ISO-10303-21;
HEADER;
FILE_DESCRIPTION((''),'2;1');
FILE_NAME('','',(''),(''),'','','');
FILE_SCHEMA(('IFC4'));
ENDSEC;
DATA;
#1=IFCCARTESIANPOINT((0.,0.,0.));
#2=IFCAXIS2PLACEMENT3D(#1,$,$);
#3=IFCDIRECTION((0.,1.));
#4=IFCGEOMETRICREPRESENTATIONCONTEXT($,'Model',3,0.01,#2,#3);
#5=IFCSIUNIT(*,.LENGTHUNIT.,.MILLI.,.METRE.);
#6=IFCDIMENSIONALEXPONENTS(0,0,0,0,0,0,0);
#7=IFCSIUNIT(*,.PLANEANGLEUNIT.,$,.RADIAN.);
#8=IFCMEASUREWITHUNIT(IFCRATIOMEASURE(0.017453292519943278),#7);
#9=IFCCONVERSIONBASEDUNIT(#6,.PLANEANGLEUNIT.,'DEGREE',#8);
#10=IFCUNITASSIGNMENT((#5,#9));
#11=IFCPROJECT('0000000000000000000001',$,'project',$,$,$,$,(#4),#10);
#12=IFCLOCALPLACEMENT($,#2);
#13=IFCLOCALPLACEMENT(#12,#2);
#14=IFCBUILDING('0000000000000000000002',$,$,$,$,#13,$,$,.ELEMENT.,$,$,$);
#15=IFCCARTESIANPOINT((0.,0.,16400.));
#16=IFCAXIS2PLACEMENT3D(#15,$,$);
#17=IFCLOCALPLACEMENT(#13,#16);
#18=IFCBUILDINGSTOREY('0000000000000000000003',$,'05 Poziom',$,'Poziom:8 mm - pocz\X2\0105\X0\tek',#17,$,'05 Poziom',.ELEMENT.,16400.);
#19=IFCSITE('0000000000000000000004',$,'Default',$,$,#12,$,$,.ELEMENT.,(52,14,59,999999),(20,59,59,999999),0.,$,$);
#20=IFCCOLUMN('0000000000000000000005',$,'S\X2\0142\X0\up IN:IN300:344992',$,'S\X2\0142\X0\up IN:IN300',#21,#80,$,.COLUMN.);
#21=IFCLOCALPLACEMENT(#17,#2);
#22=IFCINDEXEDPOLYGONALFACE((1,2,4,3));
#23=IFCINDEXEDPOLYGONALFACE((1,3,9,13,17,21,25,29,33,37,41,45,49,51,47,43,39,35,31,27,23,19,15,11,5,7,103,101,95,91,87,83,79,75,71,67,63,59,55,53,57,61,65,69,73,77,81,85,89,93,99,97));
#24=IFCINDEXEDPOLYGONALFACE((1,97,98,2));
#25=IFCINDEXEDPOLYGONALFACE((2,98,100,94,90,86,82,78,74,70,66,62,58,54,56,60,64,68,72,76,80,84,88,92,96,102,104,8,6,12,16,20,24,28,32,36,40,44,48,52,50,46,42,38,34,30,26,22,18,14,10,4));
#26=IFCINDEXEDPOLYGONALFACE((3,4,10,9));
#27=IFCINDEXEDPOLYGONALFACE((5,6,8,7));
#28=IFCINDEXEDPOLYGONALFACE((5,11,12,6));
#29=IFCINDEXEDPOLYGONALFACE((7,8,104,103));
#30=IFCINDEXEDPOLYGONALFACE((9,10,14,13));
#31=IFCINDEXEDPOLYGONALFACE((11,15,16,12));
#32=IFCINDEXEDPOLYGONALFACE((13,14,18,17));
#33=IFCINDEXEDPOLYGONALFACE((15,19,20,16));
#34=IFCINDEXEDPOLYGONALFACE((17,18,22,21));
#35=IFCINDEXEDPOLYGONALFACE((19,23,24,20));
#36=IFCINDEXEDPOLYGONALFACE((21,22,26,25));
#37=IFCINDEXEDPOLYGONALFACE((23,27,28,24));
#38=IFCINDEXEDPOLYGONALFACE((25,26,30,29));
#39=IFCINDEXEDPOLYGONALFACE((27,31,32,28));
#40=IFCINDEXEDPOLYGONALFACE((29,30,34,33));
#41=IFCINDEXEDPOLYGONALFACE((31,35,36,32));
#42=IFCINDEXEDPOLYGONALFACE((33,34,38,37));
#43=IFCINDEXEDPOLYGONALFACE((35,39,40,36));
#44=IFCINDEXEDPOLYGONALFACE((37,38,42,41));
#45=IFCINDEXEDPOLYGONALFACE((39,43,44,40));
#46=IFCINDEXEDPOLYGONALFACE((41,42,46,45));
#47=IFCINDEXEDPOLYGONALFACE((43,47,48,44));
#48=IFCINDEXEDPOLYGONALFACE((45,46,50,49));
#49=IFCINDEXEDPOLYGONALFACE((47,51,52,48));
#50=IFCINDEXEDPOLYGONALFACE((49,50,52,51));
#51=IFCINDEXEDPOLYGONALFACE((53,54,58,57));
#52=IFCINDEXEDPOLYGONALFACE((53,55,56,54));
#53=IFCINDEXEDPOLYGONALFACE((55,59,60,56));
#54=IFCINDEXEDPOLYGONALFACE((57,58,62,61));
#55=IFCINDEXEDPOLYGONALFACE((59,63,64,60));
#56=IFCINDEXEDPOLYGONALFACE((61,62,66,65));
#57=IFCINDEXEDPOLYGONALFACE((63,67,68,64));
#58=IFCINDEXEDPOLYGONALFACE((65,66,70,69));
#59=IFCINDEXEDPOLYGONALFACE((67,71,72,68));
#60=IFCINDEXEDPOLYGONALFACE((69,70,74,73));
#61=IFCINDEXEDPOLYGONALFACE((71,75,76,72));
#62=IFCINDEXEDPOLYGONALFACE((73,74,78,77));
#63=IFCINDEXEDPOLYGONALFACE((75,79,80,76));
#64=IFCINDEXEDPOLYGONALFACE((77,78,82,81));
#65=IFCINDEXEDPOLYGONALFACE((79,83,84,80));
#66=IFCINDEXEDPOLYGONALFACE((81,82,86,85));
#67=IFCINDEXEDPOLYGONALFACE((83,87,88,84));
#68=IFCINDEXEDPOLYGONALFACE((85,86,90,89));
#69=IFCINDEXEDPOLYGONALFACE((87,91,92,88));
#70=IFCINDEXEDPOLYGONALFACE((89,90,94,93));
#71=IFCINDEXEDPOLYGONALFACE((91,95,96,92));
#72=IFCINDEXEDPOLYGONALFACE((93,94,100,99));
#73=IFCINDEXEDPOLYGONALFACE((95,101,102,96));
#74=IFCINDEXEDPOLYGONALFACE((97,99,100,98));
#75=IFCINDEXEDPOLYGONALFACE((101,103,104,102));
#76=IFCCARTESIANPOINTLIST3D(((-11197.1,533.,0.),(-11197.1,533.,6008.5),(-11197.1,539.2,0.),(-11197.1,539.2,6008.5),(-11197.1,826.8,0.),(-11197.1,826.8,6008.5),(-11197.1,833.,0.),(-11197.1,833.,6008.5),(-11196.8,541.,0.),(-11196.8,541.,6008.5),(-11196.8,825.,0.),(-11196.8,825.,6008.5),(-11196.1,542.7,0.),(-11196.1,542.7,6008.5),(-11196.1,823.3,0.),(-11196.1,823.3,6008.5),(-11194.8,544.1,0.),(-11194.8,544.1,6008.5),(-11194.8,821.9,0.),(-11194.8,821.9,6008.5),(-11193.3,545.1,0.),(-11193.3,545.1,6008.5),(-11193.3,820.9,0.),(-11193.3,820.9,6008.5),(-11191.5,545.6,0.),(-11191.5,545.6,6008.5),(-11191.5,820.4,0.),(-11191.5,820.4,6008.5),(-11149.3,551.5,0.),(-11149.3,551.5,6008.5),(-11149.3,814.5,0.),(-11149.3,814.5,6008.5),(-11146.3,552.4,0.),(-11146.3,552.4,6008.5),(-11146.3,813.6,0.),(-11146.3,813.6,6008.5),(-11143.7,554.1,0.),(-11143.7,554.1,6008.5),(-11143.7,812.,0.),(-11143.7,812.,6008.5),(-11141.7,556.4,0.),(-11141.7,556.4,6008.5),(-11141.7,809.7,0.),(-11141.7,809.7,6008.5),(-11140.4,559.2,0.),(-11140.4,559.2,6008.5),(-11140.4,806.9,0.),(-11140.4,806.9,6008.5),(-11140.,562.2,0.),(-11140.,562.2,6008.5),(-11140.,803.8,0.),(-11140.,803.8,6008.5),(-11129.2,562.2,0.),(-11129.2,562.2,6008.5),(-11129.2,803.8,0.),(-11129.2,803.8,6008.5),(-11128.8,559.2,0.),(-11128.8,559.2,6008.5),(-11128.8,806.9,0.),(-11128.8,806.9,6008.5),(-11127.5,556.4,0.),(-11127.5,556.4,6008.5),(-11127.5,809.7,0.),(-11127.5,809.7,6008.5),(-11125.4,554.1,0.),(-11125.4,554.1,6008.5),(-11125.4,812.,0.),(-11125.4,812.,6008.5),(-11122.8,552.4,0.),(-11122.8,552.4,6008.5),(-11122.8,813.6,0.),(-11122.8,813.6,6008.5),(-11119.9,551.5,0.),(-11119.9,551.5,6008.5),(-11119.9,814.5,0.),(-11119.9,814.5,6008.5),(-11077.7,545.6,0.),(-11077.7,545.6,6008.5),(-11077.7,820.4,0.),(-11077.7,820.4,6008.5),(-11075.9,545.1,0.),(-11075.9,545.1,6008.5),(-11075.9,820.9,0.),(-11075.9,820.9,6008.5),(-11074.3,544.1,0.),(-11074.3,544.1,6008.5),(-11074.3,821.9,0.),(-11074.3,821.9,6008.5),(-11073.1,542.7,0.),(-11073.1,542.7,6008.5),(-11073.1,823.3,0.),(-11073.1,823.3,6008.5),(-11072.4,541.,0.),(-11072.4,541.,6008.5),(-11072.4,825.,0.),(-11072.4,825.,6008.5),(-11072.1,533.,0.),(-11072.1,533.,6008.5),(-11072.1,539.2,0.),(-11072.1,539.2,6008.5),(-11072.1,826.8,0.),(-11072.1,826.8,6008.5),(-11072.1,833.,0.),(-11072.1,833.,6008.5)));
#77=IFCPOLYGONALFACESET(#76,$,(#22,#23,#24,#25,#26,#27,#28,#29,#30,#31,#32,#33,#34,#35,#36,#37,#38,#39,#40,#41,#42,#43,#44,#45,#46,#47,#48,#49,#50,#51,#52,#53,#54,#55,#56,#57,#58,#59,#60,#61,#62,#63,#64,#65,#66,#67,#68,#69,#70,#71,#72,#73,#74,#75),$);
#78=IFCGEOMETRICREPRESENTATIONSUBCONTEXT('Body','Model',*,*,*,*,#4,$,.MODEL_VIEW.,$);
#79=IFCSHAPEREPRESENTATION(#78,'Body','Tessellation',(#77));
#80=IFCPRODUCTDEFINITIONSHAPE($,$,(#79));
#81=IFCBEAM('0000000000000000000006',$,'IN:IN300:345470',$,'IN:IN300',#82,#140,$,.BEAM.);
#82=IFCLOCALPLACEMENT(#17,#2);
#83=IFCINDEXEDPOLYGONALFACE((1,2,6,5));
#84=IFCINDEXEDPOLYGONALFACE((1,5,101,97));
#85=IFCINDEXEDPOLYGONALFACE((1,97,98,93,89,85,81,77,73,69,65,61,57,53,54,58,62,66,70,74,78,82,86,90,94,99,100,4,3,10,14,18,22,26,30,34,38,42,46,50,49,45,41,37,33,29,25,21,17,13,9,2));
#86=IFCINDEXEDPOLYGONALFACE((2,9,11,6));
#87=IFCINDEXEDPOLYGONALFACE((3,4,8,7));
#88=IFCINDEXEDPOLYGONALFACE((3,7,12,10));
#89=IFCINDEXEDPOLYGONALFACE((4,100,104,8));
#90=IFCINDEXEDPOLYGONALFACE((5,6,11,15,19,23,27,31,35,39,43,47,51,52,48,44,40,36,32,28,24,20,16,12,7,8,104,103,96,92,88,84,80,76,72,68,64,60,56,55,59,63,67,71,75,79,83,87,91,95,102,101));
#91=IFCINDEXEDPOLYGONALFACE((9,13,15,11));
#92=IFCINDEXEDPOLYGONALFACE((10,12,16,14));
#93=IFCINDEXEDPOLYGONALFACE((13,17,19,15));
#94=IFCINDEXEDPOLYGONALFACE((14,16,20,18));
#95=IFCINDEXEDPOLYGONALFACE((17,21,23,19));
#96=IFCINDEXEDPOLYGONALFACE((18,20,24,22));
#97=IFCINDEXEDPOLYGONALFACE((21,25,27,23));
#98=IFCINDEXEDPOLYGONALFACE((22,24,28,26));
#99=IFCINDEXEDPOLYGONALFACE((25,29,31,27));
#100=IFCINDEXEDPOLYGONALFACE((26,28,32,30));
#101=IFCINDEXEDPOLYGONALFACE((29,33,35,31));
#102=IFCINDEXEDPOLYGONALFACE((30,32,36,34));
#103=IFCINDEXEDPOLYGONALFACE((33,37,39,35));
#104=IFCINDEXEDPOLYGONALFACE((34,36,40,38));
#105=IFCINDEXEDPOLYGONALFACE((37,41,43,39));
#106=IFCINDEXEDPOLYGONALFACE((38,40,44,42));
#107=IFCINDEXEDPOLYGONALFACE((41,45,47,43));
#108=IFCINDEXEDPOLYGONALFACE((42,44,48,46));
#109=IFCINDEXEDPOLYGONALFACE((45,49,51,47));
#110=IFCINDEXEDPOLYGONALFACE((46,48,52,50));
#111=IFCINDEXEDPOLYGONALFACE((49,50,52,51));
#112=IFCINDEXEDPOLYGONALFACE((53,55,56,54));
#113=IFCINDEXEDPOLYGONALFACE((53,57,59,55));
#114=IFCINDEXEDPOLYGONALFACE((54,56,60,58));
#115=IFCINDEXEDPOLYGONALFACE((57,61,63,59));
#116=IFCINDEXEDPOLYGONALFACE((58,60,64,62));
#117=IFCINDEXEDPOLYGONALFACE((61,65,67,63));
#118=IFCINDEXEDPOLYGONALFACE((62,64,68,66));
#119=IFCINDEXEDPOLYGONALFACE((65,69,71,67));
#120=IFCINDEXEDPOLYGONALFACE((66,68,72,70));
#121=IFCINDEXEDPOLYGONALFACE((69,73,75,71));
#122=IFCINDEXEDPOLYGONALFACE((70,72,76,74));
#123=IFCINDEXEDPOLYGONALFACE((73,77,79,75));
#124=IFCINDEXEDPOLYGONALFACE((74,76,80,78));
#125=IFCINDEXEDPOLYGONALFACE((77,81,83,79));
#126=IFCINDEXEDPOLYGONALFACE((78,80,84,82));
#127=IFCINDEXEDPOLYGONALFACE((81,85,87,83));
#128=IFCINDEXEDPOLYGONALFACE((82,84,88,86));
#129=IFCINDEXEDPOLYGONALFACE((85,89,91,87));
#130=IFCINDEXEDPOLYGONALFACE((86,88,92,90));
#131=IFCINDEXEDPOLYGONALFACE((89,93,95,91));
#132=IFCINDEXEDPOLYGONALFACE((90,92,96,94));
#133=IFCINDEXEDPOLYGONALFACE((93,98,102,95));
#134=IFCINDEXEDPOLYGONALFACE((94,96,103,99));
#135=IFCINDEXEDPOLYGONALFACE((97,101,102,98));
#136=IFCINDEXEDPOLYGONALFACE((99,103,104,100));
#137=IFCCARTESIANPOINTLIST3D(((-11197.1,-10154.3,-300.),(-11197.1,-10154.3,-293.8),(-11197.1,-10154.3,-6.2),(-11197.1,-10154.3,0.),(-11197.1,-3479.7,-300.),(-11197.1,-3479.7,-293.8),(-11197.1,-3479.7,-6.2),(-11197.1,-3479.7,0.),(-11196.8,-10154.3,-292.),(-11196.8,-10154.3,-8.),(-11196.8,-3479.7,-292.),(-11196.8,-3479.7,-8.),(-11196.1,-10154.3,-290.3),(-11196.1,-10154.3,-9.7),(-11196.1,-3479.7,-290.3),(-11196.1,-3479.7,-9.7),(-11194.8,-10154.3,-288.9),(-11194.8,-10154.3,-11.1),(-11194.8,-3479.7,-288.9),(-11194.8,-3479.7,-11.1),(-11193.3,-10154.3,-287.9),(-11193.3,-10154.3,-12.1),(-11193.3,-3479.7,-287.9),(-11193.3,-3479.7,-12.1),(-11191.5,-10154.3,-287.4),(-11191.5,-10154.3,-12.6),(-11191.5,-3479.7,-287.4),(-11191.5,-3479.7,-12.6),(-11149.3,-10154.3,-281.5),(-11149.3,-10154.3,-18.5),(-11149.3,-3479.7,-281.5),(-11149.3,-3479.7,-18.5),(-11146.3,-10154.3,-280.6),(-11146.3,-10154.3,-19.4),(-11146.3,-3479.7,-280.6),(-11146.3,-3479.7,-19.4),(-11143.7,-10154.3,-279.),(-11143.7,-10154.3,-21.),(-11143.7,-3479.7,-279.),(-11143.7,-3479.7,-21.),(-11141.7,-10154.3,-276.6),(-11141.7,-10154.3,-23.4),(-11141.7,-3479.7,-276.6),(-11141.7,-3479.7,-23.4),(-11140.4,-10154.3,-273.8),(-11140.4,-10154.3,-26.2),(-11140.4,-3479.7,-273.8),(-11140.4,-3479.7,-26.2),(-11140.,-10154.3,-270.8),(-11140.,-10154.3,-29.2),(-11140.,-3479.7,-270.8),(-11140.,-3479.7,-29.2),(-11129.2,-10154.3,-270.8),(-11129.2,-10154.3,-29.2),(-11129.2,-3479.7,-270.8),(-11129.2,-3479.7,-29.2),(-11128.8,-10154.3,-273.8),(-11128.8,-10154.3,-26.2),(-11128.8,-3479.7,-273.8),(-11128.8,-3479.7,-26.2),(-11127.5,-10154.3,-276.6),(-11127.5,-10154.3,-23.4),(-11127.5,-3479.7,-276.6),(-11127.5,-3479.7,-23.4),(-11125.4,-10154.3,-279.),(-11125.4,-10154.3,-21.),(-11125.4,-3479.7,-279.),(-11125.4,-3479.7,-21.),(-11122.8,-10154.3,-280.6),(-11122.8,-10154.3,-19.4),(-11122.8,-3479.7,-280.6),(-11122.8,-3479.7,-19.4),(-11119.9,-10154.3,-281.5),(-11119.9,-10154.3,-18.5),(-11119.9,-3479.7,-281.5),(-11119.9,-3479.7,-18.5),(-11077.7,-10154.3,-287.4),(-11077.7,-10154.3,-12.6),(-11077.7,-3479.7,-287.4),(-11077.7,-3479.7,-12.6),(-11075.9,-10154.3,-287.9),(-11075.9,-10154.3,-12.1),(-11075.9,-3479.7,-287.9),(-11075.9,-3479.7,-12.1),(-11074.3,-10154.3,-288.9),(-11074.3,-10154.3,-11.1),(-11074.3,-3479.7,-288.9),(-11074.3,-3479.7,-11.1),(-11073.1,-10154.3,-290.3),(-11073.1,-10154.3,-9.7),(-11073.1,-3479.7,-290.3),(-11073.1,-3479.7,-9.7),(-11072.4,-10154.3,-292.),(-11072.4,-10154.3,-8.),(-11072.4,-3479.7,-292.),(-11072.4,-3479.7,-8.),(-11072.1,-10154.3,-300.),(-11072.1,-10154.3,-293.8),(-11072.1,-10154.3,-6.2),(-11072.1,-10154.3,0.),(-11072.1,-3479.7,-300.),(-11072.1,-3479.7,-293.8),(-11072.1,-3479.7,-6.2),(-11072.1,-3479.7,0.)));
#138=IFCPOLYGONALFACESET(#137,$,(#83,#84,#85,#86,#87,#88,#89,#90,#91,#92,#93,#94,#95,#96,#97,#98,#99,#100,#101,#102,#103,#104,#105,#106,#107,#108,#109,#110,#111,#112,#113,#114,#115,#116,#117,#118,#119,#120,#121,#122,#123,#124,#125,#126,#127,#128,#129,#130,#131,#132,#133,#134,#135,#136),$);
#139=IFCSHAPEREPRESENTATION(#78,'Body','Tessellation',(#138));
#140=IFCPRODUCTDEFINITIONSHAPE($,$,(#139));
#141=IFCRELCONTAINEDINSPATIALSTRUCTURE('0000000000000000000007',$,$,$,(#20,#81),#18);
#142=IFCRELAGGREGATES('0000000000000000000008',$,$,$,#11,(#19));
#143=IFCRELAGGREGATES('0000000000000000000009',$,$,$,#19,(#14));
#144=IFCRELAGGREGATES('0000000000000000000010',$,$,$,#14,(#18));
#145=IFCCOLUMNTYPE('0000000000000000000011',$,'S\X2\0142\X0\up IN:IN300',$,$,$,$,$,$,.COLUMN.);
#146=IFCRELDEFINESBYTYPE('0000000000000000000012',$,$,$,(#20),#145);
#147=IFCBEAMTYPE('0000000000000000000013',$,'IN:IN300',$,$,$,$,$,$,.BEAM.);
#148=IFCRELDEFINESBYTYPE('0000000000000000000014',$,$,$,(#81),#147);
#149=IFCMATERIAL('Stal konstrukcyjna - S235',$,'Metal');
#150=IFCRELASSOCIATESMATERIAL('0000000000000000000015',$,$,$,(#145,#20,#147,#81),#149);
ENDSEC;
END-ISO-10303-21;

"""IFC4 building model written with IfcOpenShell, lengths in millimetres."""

from ifc_helpers import new_model, entity, si_unit, converted_unit, direction, frame, origin, place, context, subcontext, project, spatial, line, arc, indexed_curve, outline, extrude, source, transform, mapped, material, type_object, type_shapes, element, save


model = new_model("IFC4")

# Units and contexts
model_context = context("Model", 3, precision=0.01, world=origin(), true_north=direction((0.0, 1.0)))
body_context = subcontext(model_context, "Body", "Model", "MODEL_VIEW")
ifc_project = project(units=[si_unit("LENGTHUNIT", "METRE", prefix="MILLI"), converted_unit("PLANEANGLEUNIT", "DEGREE", entity("IfcRatioMeasure", 0.017453292519943278), si_unit("PLANEANGLEUNIT", "RADIAN"), dimensions=[0, 0, 0, 0, 0, 0, 0])], contexts=[model_context])

# Site, building, storey
site_placement = place(None, origin())
site = spatial("IfcSite", under=ifc_project, at=site_placement, Name="Default", CompositionType="ELEMENT", RefLatitude=(52, 14, 59, 999999), RefLongitude=(20, 59, 59, 999999), RefElevation=0.0)
building_placement = place(site_placement, origin())
building = spatial("IfcBuilding", under=site, at=building_placement, CompositionType="ELEMENT")
storey_placement = place(building_placement, frame((0.0, 0.0, 16400.0)))
storey = spatial("IfcBuildingStorey", under=building, at=storey_placement, Name="05 Poziom", ObjectType="Poziom:8 mm - początek", LongName="05 Poziom", CompositionType="ELEMENT", Elevation=16400.0)

# Column
ifc_material = material(Name="Stal konstrukcyjna - S235", Category="Metal")
column_type_1 = type_object("IfcColumnType", Name="Słup IN:IN300", PredefinedType="COLUMN", material=ifc_material)
shared_shape_1 = source(origin(), body_context, "Body", "SweptSolid", [
    extrude(outline(indexed_curve([(143.8, -62.5), (150.0, -62.5), (150.0, 62.5), (143.8, 62.5), (139.6, 60.9), (137.4, 56.9), (131.5, 14.7), (127.9, 8.1), (120.8, 5.4), (-120.8, 5.4), (-127.9, 8.1), (-131.5, 14.7), (-137.4, 56.9), (-139.6, 60.9), (-143.8, 62.5), (-150.0, 62.5), (-150.0, -62.5), (-143.8, -62.5), (-139.6, -60.9), (-137.4, -56.9), (-131.5, -14.7), (-127.9, -8.1), (-120.8, -5.4), (120.8, -5.4), (127.9, -8.1), (131.5, -14.7), (137.4, -56.9), (139.6, -60.9)], segments=[line(1, 2, 3, 4), arc(4, 5, 6), line(6, 7), arc(7, 8, 9), line(9, 10), arc(10, 11, 12), line(12, 13), arc(13, 14, 15), line(15, 16, 17, 18), arc(18, 19, 20), line(20, 21), arc(21, 22, 23), line(23, 24), arc(24, 25, 26), line(26, 27), arc(27, 28, 1)], self_intersect=False)), frame((-11134.6, 683.0, 16400.0), z_axis=(0.0, 0.0, 1.0), x_axis=(0.0, -1.0, 0.0)), (0.0, 0.0, 1.0), 6008.5),
])
type_shapes(column_type_1, [shared_shape_1])
column_1_placement = place(storey_placement, frame((0.0, 0.0, -16400.0)))
element("IfcColumn", 1, at=column_1_placement, inside=storey, type_object=column_type_1, material=ifc_material, Name="Słup IN:IN300:344992", ObjectType="Słup IN:IN300", PredefinedType="COLUMN", context=body_context, shape_type="MappedRepresentation", body=[
    mapped(shared_shape_1, transform((0.0, 0.0, 0.0), scale=1.0)),
])

# Beam
beam_type_1 = type_object("IfcBeamType", Name="IN:IN300", PredefinedType="BEAM", material=ifc_material)
shared_shape_2 = source(origin(), body_context, "Body", "SweptSolid", [
    extrude(outline(indexed_curve([(143.8, -62.5), (150.0, -62.5), (150.0, 62.5), (143.8, 62.5), (139.6, 60.9), (137.4, 56.9), (131.5, 14.7), (127.9, 8.1), (120.8, 5.4), (-120.8, 5.4), (-127.9, 8.1), (-131.5, 14.7), (-137.4, 56.9), (-139.6, 60.9), (-143.8, 62.5), (-150.0, 62.5), (-150.0, -62.5), (-143.8, -62.5), (-139.6, -60.9), (-137.4, -56.9), (-131.5, -14.7), (-127.9, -8.1), (-120.8, -5.4), (120.8, -5.4), (127.9, -8.1), (131.5, -14.7), (137.4, -56.9), (139.6, -60.9)], segments=[line(1, 2, 3, 4), arc(4, 5, 6), line(6, 7), arc(7, 8, 9), line(9, 10), arc(10, 11, 12), line(12, 13), arc(13, 14, 15), line(15, 16, 17, 18), arc(18, 19, 20), line(20, 21), arc(21, 22, 23), line(23, 24), arc(24, 25, 26), line(26, 27), arc(27, 28, 1)], self_intersect=False)), frame((-3337.3, 0.0, 0.0), z_axis=(1.0, 0.0, 0.0), x_axis=(0.0, 0.0, -1.0)), (0.0, 0.0, 1.0), 6674.6),
])
type_shapes(beam_type_1, [shared_shape_2])
for number, where, z_axis, x_axis, name in (
    (2, (-11134.6, -6817.0, -150.0), (0.0, 0.0, 1.0), (0.0, 1.0, 0.0), "IN:IN300:345470"),
):
    element("IfcBeam", number, at=place(storey_placement, frame(where, z_axis=z_axis, x_axis=x_axis)), inside=storey, type_object=beam_type_1, material=ifc_material, Name=name, ObjectType="IN:IN300", PredefinedType="BEAM", context=body_context, shape_type="MappedRepresentation", body=[
        mapped(shared_shape_2, transform((0.0, 0.0, 0.0), scale=1.0)),
    ])

save(model, "model.ifc")
